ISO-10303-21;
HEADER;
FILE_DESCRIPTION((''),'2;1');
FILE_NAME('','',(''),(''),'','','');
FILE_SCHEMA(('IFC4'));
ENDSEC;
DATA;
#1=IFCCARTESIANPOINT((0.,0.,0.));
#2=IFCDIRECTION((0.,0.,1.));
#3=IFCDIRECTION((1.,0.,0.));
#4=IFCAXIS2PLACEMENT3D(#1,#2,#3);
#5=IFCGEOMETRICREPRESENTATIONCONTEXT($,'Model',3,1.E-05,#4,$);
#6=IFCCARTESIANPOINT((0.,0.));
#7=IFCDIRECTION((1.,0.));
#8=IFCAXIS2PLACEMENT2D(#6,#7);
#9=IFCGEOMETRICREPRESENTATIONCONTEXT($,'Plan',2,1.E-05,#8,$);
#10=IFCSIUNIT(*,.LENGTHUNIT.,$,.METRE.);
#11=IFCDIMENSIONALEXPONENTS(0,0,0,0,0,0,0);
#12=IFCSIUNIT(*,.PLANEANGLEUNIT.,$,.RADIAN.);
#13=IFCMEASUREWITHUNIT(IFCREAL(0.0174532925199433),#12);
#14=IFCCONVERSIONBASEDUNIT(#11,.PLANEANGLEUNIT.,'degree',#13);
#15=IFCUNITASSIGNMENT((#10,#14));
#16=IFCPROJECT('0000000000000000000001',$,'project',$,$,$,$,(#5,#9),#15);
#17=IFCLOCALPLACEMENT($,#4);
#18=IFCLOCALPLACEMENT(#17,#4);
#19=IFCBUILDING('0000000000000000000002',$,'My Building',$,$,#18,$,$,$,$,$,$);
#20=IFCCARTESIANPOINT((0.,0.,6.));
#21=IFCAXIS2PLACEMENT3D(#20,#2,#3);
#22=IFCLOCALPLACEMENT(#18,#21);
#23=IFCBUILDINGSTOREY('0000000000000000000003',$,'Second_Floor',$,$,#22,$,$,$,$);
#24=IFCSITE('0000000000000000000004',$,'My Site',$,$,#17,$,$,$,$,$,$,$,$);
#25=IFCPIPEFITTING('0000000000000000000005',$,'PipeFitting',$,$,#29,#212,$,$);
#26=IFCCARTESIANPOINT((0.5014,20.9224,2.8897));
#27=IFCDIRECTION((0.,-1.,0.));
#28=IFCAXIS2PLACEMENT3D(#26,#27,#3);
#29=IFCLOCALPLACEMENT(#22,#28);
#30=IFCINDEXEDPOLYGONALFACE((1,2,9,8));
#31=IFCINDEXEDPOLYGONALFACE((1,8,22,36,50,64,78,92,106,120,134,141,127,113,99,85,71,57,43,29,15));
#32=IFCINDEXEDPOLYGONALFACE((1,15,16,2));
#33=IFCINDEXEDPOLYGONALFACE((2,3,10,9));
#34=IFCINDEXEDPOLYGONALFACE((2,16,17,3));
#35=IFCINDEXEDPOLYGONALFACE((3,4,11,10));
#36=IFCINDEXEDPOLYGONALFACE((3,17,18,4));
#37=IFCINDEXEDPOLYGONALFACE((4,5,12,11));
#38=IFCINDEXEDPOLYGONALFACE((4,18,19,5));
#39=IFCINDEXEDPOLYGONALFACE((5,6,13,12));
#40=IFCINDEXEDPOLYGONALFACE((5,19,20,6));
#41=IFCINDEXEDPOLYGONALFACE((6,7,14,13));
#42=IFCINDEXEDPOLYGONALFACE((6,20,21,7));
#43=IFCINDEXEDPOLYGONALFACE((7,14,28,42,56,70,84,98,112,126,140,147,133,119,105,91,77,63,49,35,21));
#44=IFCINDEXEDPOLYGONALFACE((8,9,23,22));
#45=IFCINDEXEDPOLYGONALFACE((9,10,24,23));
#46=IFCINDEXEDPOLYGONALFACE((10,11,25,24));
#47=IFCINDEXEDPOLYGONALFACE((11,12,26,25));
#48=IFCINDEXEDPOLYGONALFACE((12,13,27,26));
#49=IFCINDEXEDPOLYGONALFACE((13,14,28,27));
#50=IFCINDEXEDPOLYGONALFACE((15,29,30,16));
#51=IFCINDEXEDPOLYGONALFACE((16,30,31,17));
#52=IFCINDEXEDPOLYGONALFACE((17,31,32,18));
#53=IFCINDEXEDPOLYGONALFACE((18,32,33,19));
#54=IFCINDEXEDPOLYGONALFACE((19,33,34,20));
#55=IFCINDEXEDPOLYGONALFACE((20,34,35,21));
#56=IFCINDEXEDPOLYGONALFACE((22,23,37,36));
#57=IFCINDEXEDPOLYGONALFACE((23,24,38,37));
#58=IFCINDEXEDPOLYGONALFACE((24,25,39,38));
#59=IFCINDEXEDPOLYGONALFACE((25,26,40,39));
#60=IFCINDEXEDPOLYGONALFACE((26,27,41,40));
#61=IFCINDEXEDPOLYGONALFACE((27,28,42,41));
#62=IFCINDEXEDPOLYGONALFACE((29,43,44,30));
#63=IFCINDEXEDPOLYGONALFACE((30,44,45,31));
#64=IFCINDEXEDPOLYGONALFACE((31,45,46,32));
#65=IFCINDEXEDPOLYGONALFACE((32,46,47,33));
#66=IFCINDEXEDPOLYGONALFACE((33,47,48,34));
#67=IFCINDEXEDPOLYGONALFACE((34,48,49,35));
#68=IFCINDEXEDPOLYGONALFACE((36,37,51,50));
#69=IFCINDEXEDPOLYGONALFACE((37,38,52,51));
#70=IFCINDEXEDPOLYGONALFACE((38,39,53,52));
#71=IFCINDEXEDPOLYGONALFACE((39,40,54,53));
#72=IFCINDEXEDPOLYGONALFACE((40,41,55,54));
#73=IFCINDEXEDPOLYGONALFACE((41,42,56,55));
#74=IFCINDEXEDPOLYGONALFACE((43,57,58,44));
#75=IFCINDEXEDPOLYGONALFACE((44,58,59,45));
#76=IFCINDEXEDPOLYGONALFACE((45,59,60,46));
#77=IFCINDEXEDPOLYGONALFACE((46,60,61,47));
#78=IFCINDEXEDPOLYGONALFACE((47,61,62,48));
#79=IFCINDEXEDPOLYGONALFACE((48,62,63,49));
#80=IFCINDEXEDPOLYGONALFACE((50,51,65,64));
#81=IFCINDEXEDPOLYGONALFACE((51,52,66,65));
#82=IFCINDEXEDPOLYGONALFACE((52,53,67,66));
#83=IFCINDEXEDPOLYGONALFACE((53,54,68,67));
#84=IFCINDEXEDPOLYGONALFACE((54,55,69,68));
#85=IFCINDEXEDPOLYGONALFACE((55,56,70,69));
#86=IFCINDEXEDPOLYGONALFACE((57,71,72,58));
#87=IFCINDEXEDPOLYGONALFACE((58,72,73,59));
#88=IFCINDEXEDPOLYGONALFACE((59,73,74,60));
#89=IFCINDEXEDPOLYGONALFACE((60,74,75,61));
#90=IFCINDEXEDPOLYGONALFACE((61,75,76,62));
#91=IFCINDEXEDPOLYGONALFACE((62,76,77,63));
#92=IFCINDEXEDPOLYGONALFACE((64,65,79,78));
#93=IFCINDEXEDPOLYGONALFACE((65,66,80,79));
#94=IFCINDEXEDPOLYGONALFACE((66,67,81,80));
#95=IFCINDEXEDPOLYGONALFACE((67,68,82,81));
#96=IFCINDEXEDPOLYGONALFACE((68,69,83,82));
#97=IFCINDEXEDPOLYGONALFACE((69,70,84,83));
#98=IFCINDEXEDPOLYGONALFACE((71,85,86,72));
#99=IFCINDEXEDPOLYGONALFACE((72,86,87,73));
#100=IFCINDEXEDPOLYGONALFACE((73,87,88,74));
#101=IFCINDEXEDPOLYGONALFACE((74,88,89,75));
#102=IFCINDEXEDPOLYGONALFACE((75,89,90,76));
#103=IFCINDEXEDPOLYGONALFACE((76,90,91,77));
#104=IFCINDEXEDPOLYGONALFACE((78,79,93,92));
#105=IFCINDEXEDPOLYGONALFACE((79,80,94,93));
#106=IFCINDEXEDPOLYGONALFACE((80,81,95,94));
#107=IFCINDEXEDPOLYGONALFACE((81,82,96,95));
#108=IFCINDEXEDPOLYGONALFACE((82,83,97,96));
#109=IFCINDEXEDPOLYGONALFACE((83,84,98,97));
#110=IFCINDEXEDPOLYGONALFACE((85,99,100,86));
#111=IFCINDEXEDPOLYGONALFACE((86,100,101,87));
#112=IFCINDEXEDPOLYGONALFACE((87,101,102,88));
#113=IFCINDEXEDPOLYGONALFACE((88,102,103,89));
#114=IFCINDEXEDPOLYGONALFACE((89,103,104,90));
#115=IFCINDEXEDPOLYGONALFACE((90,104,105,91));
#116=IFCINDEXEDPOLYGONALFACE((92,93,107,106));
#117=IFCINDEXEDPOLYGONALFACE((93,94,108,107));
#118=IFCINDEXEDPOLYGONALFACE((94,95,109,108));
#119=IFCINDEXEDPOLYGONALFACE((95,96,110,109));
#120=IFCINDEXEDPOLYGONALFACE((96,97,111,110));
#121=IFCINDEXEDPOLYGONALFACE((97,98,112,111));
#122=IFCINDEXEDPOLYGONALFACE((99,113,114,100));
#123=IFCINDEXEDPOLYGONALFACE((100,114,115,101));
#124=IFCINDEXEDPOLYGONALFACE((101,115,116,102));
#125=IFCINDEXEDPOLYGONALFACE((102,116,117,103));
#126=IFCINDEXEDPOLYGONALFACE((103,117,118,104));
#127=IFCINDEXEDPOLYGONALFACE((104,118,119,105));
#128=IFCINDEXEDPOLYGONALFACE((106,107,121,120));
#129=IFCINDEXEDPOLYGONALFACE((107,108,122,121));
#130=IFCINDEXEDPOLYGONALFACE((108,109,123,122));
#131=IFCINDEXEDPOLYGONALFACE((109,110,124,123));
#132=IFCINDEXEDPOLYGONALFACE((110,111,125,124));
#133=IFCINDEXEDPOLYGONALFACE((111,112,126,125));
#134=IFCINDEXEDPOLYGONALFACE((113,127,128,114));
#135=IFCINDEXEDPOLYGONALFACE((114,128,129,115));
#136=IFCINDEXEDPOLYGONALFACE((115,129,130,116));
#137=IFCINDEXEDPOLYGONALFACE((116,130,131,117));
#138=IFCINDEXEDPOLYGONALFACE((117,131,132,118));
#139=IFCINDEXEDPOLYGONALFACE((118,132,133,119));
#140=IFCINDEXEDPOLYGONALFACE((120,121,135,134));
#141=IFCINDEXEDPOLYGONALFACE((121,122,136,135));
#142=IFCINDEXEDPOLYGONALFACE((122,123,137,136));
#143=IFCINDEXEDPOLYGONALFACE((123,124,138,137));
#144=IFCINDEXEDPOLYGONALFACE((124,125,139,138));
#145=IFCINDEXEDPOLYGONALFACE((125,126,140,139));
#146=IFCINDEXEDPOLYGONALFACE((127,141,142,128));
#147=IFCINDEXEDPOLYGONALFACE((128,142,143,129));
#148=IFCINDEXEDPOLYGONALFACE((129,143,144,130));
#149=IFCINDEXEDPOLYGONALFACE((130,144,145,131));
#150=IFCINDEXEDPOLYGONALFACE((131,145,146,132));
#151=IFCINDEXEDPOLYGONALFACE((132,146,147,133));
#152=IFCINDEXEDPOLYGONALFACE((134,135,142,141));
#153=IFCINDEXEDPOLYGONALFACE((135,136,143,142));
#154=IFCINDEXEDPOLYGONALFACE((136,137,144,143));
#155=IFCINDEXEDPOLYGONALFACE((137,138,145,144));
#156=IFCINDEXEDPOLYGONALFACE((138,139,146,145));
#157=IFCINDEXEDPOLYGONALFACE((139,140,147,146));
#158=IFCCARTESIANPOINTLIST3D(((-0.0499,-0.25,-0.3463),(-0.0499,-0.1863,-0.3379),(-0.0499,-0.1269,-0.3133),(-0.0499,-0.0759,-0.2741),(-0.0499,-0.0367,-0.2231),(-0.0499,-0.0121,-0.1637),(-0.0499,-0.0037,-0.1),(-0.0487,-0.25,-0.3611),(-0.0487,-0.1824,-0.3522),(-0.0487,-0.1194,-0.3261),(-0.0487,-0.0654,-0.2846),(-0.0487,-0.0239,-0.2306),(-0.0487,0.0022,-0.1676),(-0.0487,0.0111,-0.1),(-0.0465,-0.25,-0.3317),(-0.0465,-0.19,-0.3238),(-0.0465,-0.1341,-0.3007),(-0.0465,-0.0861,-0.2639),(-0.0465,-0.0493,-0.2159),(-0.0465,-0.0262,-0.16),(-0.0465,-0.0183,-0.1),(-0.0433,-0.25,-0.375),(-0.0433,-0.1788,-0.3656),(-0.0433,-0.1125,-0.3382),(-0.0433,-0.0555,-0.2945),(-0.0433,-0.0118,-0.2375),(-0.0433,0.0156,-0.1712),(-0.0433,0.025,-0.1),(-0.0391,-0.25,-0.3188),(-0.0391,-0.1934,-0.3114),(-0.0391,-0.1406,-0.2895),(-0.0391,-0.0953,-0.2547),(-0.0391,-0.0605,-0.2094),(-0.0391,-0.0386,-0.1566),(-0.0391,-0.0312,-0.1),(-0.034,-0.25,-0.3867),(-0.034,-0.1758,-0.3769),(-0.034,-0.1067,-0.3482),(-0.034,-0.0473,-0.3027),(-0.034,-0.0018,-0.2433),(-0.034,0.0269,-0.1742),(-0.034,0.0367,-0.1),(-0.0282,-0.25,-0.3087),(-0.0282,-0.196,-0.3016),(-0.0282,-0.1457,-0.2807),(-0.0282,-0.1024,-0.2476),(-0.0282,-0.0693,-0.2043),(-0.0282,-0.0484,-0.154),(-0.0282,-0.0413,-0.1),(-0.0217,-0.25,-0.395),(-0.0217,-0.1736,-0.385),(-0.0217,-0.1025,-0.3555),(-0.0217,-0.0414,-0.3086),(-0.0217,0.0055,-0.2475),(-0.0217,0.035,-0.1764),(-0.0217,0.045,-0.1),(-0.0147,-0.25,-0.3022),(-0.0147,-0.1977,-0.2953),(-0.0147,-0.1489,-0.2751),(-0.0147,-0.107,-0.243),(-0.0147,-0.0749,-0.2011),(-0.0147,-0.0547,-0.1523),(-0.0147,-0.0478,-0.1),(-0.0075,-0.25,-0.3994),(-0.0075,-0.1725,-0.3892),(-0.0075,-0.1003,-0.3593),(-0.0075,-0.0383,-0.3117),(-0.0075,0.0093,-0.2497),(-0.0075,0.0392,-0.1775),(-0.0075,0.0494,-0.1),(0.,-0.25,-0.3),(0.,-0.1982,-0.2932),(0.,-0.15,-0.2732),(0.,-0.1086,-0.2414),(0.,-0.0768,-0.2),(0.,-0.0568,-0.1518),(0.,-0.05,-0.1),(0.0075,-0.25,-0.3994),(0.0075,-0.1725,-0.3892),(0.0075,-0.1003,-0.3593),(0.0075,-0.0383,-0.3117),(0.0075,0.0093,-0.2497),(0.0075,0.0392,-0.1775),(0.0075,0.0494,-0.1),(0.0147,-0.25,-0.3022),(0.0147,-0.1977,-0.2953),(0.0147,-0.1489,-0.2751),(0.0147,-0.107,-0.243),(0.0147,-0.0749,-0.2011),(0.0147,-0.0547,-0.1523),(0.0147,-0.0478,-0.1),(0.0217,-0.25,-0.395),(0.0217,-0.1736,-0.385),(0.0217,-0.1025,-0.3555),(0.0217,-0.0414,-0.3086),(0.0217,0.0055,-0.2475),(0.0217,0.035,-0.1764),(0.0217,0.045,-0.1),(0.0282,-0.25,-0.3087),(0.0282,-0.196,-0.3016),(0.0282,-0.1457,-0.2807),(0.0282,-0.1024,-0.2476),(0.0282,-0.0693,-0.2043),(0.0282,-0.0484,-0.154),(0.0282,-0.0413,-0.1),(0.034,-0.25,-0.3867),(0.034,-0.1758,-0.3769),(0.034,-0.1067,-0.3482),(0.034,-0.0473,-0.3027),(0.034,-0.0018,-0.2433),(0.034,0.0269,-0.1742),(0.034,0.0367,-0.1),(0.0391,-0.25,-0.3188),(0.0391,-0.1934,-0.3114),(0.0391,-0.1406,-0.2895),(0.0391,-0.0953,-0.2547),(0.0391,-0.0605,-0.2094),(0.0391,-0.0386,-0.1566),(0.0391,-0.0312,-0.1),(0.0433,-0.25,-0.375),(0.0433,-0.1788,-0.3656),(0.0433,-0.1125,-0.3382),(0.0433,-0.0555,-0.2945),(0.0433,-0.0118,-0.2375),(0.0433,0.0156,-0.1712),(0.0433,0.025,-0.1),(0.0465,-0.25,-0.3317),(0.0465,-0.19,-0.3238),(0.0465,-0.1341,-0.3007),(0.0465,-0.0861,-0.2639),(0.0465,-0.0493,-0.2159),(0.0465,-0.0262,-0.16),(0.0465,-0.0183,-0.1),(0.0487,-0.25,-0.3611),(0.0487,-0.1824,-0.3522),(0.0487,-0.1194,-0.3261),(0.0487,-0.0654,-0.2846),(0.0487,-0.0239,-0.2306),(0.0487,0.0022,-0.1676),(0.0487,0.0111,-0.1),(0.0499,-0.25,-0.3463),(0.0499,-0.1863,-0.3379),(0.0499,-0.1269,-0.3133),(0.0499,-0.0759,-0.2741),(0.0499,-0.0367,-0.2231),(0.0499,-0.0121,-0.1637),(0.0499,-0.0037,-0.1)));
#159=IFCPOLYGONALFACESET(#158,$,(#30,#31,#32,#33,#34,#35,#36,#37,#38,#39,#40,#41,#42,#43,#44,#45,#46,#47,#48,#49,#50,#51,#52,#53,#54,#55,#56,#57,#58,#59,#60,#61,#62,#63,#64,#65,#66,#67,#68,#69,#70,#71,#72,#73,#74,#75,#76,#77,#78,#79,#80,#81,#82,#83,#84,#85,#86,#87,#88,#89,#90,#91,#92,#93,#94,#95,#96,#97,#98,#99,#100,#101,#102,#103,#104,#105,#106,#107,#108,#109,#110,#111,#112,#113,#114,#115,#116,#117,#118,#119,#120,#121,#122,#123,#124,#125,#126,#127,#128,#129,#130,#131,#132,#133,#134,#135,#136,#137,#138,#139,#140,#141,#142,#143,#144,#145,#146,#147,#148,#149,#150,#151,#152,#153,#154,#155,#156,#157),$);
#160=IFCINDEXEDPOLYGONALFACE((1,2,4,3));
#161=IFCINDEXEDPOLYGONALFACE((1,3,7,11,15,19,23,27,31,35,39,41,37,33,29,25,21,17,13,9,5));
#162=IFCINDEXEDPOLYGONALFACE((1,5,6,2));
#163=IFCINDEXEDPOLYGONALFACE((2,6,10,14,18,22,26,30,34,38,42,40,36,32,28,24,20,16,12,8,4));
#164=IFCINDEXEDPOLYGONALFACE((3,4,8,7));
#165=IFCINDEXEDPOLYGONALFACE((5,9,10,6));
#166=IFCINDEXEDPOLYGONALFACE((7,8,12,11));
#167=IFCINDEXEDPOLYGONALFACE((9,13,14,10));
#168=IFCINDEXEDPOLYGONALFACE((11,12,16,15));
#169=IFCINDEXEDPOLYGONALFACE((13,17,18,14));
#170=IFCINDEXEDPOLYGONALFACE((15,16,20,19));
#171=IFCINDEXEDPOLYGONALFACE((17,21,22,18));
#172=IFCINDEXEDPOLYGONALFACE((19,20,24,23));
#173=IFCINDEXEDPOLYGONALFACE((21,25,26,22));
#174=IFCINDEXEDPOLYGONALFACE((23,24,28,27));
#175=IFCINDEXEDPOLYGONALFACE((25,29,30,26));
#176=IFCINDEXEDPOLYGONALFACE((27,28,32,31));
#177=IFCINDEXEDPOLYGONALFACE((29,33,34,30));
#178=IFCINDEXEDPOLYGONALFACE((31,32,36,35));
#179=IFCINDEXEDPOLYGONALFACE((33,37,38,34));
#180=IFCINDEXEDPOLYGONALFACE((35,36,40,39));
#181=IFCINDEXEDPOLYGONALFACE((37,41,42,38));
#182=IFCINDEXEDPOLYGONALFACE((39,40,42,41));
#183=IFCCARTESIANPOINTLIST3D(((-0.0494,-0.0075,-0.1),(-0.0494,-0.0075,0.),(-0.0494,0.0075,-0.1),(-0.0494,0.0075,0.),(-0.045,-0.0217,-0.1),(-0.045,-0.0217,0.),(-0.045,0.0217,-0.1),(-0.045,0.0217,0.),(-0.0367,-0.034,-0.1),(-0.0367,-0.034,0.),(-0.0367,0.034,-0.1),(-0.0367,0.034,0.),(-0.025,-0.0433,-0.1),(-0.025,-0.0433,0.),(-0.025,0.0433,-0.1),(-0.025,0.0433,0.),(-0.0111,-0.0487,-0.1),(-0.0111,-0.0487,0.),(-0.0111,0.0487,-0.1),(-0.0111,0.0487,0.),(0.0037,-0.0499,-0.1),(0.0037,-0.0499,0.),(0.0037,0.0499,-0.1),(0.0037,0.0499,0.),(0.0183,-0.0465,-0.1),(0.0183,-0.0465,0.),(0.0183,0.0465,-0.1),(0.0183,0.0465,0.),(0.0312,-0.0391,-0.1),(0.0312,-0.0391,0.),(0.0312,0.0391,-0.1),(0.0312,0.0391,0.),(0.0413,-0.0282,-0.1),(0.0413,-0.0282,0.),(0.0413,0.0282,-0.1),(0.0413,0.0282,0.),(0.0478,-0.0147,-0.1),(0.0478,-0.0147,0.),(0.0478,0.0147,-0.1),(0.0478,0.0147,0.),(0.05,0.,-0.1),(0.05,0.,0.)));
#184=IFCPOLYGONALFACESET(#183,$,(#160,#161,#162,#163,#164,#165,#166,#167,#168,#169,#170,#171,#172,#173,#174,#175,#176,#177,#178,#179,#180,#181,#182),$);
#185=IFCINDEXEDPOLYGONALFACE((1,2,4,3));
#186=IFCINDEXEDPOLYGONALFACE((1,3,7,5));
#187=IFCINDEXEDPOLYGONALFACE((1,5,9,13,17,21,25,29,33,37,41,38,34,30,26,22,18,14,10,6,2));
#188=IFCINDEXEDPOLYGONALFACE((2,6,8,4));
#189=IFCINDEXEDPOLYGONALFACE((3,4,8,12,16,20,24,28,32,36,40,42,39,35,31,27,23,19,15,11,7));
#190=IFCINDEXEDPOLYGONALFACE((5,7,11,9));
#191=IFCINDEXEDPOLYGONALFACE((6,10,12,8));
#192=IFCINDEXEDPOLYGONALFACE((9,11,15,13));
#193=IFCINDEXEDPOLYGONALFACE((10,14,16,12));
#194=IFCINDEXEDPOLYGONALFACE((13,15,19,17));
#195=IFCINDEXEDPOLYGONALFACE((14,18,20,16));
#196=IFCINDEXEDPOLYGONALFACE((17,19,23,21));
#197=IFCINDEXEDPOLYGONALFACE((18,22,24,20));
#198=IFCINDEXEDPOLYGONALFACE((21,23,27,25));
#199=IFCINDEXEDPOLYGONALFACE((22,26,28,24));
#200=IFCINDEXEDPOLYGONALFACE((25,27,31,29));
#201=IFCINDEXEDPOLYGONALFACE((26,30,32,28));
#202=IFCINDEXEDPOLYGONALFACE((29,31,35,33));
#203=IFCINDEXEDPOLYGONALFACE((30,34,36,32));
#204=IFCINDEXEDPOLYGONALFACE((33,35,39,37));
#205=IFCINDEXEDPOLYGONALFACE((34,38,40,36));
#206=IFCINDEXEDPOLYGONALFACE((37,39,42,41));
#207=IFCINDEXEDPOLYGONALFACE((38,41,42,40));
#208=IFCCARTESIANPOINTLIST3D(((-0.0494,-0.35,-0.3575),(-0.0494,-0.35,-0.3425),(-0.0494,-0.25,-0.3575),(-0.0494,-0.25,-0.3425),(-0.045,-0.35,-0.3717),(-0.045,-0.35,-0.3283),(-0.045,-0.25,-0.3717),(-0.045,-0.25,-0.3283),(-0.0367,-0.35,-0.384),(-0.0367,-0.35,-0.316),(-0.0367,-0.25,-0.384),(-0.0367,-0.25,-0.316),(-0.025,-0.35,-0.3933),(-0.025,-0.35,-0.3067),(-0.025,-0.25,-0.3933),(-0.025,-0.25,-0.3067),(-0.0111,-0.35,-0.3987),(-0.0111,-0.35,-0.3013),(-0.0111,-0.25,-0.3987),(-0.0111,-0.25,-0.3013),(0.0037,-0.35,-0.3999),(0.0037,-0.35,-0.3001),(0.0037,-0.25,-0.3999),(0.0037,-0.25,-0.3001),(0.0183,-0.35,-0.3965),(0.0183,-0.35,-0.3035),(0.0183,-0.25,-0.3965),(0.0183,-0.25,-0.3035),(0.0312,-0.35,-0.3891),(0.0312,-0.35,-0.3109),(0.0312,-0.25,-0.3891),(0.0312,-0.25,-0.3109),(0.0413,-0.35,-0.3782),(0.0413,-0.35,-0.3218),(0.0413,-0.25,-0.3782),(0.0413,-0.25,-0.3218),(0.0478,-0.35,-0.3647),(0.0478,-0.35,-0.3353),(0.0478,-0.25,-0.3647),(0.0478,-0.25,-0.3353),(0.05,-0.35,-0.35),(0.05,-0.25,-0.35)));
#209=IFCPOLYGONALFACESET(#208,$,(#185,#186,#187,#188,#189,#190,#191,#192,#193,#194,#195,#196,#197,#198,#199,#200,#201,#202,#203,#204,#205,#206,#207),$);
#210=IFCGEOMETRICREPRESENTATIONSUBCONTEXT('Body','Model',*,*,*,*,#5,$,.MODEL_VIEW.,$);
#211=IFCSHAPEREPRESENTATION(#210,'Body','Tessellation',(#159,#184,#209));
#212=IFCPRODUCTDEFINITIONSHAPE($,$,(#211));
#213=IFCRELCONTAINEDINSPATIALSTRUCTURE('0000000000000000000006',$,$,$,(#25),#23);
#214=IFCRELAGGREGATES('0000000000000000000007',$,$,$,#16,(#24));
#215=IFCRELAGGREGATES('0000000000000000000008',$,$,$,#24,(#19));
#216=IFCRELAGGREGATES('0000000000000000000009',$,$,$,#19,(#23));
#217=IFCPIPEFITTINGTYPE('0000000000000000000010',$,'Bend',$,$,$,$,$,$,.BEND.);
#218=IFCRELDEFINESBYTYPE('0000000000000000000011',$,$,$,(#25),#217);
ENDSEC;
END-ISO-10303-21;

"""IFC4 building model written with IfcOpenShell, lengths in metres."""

from ifc_helpers import new_model, entity, si_unit, converted_unit, frame, origin_with_axes, origin_2d_with_axis, place, context, subcontext, project, spatial, circle, extrude, source, transform, mapped, type_object, type_shapes, element, save


model = new_model("IFC4")

# Units and contexts
model_context = context("Model", 3, precision=1e-05, world=origin_with_axes())
plan_context = context("Plan", 2, precision=1e-05, world=origin_2d_with_axis())
body_context_1 = subcontext(model_context, "Body", "Model", "MODEL_VIEW")
ifc_project = project(units=[si_unit("LENGTHUNIT", "METRE"), converted_unit("PLANEANGLEUNIT", "degree", entity("IfcReal", 0.0174532925199433), si_unit("PLANEANGLEUNIT", "RADIAN"), dimensions=[0, 0, 0, 0, 0, 0, 0])], contexts=[model_context, plan_context])

# Site, building, storey
site_placement = place(None, origin_with_axes())
site = spatial("IfcSite", under=ifc_project, at=site_placement, Name="My Site")
building_placement = place(site_placement, origin_with_axes())
building = spatial("IfcBuilding", under=site, at=building_placement, Name="My Building")
storey_placement = place(building_placement, frame((0.0, 0.0, 6.0), z_axis=(0.0, 0.0, 1.0), x_axis=(1.0, 0.0, 0.0)))
storey = spatial("IfcBuildingStorey", under=building, at=storey_placement, Name="Second_Floor")

# Pipe fitting
pipe_fitting_type = type_object("IfcPipeFittingType", Name="Bend", PredefinedType="BEND")
shared_shape_1 = source(origin_with_axes(), body_context_1, "Body", "SolidModel", [
    entity("IfcSweptDiskSolid", entity("IfcIndexedPolyCurve", entity("IfcCartesianPointList3D", [[0.0, 0.0, -0.1], [0.0, -0.0732, -0.2768], [0.0, -0.25, -0.35]]), [entity("IfcArcIndex", [1, 2, 3])]), 0.05),
    extrude(circle(Radius=0.05), origin_with_axes(), (0.0, 0.0, -1.0), 0.1),
    extrude(circle(Radius=0.05), frame((0.0, -0.25, -0.35), z_axis=(0.0, -1.0, 0.0), x_axis=(1.0, 0.0, 0.0)), (0.0, 0.0, 1.0), 0.1),
])
type_shapes(pipe_fitting_type, [shared_shape_1])
for number, where, z_axis, x_axis, name in (
    (1, (0.5014, 20.9224, 2.8897), (0.0, -1.0, 0.0), (1.0, 0.0, 0.0), "PipeFitting"),
):
    element("IfcPipeFitting", number, at=place(storey_placement, frame(where, z_axis=z_axis, x_axis=x_axis)), inside=storey, type_object=pipe_fitting_type, Name=name, context=body_context_1, shape_type="MappedRepresentation", body=[
        mapped(shared_shape_1, transform((0.0, 0.0, 0.0), x_axis=(1.0, 0.0, 0.0), y_axis=(0.0, 1.0, 0.0), z_axis=(0.0, 0.0, 1.0), scale=1.0)),
    ])

save(model, "model.ifc")
